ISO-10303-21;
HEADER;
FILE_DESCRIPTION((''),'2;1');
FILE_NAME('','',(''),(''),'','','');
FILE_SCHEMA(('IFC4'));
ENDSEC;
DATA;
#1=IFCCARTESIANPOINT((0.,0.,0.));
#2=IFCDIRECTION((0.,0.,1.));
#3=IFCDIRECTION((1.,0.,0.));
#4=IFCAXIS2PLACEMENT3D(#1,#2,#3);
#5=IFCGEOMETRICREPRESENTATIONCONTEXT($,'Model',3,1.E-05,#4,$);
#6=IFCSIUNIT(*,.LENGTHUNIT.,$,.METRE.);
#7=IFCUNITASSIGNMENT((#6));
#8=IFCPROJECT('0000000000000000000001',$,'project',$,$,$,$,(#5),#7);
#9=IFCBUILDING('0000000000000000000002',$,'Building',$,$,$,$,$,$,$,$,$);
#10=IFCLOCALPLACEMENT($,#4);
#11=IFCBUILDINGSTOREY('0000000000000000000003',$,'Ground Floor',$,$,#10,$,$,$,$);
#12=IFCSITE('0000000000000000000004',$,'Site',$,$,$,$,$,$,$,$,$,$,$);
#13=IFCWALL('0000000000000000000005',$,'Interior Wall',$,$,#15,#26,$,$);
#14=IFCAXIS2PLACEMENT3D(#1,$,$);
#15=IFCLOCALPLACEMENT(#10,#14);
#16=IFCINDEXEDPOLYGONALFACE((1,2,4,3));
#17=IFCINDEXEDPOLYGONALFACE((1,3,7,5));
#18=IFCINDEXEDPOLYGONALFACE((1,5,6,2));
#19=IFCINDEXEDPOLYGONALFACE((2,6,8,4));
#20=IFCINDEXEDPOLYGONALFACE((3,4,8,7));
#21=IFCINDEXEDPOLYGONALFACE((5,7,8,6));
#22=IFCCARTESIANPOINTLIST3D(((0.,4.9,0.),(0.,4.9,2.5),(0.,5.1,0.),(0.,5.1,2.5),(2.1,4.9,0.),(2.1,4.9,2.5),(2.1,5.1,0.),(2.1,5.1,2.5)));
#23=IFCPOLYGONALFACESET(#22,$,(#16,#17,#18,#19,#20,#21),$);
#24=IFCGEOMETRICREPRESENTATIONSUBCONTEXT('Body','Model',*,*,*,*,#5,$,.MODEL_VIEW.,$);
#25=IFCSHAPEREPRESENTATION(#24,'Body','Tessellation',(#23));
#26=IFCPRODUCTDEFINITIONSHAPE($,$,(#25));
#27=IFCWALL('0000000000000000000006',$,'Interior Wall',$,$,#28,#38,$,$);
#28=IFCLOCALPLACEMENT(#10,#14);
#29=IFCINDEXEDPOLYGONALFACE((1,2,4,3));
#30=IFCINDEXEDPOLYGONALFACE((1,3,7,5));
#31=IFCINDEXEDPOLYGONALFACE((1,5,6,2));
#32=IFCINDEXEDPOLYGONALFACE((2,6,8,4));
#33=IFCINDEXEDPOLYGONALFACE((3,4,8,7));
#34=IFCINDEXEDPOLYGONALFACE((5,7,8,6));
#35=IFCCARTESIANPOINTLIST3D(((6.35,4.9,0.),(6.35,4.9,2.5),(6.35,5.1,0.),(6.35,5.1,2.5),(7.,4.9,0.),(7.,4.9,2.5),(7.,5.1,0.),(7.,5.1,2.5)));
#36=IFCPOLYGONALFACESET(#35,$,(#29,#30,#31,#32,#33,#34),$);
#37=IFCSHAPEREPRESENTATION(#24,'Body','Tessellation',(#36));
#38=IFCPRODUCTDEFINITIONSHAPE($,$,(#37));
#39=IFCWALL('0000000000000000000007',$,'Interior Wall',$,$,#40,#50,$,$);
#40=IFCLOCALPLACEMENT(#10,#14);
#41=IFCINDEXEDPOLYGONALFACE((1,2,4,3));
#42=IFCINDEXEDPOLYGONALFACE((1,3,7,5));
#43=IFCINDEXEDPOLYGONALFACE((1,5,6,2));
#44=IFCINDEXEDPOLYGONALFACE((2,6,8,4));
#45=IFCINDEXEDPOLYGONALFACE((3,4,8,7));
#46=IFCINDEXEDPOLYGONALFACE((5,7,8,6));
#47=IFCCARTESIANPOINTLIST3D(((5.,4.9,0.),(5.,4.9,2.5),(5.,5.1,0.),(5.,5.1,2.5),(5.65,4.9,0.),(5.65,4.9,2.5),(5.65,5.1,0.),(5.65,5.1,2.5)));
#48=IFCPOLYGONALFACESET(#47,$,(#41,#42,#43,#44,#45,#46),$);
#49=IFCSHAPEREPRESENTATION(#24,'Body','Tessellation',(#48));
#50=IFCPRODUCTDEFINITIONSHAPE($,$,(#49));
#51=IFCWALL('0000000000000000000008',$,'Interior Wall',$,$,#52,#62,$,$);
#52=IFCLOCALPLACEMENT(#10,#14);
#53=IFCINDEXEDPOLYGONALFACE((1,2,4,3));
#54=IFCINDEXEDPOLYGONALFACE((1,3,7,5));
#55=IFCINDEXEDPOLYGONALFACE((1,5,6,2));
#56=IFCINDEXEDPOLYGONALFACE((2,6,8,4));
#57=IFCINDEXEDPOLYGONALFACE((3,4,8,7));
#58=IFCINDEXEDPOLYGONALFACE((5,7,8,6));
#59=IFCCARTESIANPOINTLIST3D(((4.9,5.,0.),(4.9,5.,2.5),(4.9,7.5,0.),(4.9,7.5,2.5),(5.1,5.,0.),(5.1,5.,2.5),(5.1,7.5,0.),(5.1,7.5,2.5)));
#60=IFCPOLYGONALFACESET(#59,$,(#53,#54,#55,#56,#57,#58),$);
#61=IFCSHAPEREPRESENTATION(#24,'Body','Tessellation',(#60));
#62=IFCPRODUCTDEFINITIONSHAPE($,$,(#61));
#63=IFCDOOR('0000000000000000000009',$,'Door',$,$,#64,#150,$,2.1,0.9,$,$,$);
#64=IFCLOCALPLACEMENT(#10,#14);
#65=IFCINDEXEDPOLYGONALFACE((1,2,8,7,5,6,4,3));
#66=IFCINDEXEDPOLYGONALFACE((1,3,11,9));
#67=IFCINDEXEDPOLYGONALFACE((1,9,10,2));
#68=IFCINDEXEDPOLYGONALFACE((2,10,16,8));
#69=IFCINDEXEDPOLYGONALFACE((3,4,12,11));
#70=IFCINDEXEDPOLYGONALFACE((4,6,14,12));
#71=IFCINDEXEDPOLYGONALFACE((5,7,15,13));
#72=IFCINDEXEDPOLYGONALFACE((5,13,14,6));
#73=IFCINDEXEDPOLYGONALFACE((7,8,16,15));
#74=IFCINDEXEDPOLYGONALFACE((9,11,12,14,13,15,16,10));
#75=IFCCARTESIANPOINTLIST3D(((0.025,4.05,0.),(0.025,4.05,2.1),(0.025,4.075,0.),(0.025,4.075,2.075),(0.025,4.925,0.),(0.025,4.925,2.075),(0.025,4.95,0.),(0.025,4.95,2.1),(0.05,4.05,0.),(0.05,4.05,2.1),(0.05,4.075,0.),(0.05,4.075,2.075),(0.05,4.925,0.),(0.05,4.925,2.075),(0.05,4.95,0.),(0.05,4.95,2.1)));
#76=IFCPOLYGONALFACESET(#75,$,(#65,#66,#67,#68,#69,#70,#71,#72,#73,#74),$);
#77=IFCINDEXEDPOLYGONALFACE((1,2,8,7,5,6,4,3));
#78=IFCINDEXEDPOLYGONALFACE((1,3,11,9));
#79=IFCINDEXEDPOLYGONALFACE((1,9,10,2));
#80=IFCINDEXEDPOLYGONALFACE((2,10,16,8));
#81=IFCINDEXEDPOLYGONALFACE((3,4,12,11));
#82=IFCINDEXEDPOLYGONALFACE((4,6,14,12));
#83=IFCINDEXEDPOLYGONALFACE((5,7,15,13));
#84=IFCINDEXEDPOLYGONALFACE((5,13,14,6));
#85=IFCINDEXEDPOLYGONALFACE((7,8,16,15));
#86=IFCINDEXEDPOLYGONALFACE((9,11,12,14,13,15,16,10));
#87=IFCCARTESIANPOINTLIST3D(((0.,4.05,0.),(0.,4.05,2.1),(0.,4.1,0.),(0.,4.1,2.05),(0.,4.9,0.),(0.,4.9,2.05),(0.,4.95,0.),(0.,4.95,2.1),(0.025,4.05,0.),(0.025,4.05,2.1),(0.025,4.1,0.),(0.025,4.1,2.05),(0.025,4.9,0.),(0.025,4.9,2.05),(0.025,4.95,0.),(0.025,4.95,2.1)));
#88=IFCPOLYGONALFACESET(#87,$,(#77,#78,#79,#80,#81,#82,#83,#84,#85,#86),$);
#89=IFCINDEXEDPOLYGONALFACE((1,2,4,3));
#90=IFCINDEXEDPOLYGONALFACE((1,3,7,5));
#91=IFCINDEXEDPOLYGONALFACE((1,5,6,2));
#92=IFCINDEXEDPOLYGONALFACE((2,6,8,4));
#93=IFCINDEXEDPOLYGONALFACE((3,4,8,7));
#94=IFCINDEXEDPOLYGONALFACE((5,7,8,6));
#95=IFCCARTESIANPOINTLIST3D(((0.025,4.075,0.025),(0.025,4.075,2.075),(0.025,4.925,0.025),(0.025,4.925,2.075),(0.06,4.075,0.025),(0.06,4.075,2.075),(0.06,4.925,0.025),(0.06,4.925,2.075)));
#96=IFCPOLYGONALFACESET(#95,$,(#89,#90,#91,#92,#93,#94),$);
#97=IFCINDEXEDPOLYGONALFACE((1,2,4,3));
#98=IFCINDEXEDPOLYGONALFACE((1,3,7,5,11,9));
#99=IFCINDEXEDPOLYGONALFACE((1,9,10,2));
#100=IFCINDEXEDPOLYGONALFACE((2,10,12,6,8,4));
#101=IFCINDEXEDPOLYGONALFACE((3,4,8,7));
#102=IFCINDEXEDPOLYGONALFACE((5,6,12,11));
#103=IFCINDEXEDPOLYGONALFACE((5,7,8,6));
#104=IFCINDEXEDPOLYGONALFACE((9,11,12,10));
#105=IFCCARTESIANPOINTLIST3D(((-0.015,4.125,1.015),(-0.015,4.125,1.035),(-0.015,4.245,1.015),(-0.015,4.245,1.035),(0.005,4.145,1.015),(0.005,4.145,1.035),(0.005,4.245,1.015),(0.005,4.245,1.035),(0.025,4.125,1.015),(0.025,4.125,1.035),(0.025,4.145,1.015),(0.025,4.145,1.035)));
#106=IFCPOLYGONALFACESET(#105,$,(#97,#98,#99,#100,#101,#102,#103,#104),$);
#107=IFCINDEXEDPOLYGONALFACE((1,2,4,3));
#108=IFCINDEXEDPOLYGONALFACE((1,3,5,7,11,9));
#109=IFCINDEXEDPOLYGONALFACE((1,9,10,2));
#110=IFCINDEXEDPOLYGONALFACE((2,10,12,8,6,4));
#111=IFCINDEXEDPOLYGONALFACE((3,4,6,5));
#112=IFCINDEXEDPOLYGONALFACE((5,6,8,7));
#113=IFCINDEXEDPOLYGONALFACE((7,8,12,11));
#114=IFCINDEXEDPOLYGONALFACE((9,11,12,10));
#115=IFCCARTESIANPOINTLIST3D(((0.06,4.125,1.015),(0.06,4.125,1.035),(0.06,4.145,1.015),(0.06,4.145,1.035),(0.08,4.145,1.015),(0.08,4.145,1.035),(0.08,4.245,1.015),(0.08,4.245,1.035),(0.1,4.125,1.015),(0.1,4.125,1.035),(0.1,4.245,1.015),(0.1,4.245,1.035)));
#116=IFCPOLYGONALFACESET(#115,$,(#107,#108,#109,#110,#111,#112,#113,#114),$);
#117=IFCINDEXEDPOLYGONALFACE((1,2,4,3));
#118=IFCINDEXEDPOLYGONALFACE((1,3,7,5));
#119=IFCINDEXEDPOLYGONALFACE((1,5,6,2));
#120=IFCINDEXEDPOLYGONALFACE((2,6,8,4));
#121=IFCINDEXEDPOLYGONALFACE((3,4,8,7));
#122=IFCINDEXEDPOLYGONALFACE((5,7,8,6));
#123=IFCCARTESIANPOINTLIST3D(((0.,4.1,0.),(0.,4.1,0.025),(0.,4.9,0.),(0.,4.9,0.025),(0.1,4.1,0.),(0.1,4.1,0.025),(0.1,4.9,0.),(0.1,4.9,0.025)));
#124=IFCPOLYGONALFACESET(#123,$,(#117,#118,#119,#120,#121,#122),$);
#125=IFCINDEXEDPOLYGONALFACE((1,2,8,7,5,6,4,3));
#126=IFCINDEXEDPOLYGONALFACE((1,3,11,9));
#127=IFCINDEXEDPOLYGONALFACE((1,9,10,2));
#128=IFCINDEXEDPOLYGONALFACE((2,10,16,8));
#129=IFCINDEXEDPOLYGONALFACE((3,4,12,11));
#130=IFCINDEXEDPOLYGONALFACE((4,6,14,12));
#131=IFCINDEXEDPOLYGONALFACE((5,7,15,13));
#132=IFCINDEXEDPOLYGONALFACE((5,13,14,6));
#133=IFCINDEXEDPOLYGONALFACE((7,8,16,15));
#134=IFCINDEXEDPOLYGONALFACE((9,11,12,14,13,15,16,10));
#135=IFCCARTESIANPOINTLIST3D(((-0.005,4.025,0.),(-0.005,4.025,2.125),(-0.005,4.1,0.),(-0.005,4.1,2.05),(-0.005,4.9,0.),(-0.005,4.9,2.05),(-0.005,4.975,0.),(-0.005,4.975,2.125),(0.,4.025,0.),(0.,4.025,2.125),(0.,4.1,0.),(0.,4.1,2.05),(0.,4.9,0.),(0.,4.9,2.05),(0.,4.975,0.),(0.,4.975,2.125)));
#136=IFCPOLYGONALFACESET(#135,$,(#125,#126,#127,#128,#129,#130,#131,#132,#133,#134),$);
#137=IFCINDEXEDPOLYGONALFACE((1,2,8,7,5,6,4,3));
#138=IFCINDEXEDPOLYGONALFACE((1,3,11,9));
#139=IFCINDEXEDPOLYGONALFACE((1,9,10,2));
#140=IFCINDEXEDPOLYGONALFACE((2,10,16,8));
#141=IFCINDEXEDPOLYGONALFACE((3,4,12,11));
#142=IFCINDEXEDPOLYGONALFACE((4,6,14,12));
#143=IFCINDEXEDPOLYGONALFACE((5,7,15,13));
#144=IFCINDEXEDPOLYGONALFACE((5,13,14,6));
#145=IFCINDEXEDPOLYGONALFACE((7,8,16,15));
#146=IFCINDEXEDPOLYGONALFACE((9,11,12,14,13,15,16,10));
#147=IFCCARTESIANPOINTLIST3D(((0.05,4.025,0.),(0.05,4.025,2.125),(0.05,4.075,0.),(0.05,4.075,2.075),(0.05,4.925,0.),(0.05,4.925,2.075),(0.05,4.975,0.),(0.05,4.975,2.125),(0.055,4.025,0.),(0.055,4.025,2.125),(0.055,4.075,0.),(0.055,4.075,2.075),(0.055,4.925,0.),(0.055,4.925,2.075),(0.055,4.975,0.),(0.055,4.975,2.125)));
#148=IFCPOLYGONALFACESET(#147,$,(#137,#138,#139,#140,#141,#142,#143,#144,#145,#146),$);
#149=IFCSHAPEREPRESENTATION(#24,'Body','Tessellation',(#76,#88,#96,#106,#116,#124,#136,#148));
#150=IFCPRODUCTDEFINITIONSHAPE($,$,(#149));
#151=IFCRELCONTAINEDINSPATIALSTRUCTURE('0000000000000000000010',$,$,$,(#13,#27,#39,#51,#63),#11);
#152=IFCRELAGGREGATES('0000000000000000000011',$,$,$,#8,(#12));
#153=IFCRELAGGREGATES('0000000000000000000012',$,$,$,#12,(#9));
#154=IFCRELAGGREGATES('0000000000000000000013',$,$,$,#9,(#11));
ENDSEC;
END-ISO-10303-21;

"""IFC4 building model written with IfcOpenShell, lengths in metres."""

from ifc_helpers import new_model, si_unit, frame, origin_with_axes, place, context, subcontext, project, spatial, line, indexed_curve, outline, extrude, element, save


model = new_model("IFC4")

# Units and contexts
model_context = context("Model", 3, precision=1e-05, world=origin_with_axes())
body_context = subcontext(model_context, "Body", "Model", "MODEL_VIEW")
ifc_project = project(units=[si_unit("LENGTHUNIT", "METRE")], contexts=[model_context])

# Site, building, storey
site = spatial("IfcSite", under=ifc_project, Name="Site")
building = spatial("IfcBuilding", under=site, Name="Building")
storey_placement = place(None, origin_with_axes())
storey = spatial("IfcBuildingStorey", under=building, at=storey_placement, Name="Ground Floor")

# Walls
for number, where, z_axis, x_axis, name in (
    (1, (2.1, 5.0, 0.0), (0.0, 0.0, 1.0), (-1.0, 0.0, 0.0), "Interior Wall"),
):
    element("IfcWall", number, at=place(storey_placement, frame(where, z_axis=z_axis, x_axis=x_axis)), inside=storey, Name=name, context=body_context, shape_type="SweptSolid", body=[
        extrude(outline(indexed_curve([(0.0, 0.0), (0.0, 0.2), (2.1, 0.2), (2.1, 0.0), (0.0, 0.0)], self_intersect=False)), frame((0.0, -0.1, 0.0), z_axis=(0.0, 0.0, 1.0), x_axis=(1.0, 0.0, 0.0)), (0.0, 0.0, 1.0), 2.5),
    ])
for number, where, z_axis, x_axis, name in (
    (2, (7.0, 5.0, 0.0), (0.0, 0.0, 1.0), (-1.0, 0.0, 0.0), "Interior Wall"),
    (3, (5.65, 5.0, 0.0), (0.0, 0.0, 1.0), (-1.0, 0.0, 0.0), "Interior Wall"),
):
    element("IfcWall", number, at=place(storey_placement, frame(where, z_axis=z_axis, x_axis=x_axis)), inside=storey, Name=name, context=body_context, shape_type="SweptSolid", body=[
        extrude(outline(indexed_curve([(0.0, 0.0), (0.0, 0.2), (0.65, 0.2), (0.65, 0.0), (0.0, 0.0)], self_intersect=False)), frame((0.0, -0.1, 0.0), z_axis=(0.0, 0.0, 1.0), x_axis=(1.0, 0.0, 0.0)), (0.0, 0.0, 1.0), 2.5),
    ])
wall_1_placement = place(storey_placement, frame((5.0, 5.0, 0.0), z_axis=(0.0, 0.0, 1.0), x_axis=(0.0, 1.0, 0.0)))
element("IfcWall", 4, at=wall_1_placement, inside=storey, Name="Interior Wall", context=body_context, shape_type="SweptSolid", body=[
    extrude(outline(indexed_curve([(0.0, 0.0), (0.0, 0.2), (2.5, 0.2), (2.5, 0.0), (0.0, 0.0)], self_intersect=False)), frame((0.0, -0.1, 0.0), z_axis=(0.0, 0.0, 1.0), x_axis=(1.0, 0.0, 0.0)), (0.0, 0.0, 1.0), 2.5),
])

# Door
door_1_placement = place(storey_placement, frame((0.0, 4.95, 0.0), z_axis=(0.0, 0.0, 1.0), x_axis=(0.0, -1.0, 0.0)))
element("IfcDoor", 5, at=door_1_placement, inside=storey, Name="Door", OverallHeight=2.1, OverallWidth=0.9, context=body_context, shape_type="SweptSolid", body=[
    extrude(outline(indexed_curve([(0.0, 0.0), (0.0, 2.1), (0.9, 2.1), (0.9, 0.0), (0.875, 0.0), (0.875, 2.075), (0.025, 2.075), (0.025, 0.0)], segments=[line(1, 2, 3, 4, 5, 6, 7, 8, 1)])), frame((0.0, 0.025, 0.0), z_axis=(0.0, -1.0, 0.0), x_axis=(1.0, 0.0, 0.0)), (0.0, 0.0, -1.0), 0.025),
    extrude(outline(indexed_curve([(0.0, 0.0), (0.0, 2.1), (0.9, 2.1), (0.9, 0.0), (0.85, 0.0), (0.85, 2.05), (0.05, 2.05), (0.05, 0.0)], segments=[line(1, 2, 3, 4, 5, 6, 7, 8, 1)])), frame((0.0, 0.0, 0.0), z_axis=(0.0, -1.0, 0.0), x_axis=(1.0, 0.0, 0.0)), (0.0, 0.0, -1.0), 0.025),
    extrude(outline(indexed_curve([(0.0, 0.0), (0.85, 0.0), (0.85, 0.035), (0.0, 0.035)], segments=[line(1, 2, 3, 4, 1)])), frame((0.025, 0.025, 0.025), z_axis=(0.0, 0.0, 1.0), x_axis=(1.0, 0.0, 0.0)), (0.0, 0.0, 1.0), 2.05),
    extrude(outline(indexed_curve([(0.0, 0.0), (0.0, -0.04), (-0.12, -0.04), (-0.12, -0.02), (-0.02, -0.02), (-0.02, 0.0)], segments=[line(1, 2, 3, 4, 5, 6, 1)])), frame((0.825, 0.025, 1.015), z_axis=(0.0, 0.0, 1.0), x_axis=(1.0, 0.0, 0.0)), (0.0, 0.0, 1.0), 0.02),
    extrude(outline(indexed_curve([(0.0, 0.0), (0.0, 0.04), (-0.12, 0.04), (-0.12, 0.02), (-0.02, 0.02), (-0.02, 0.0)], segments=[line(1, 2, 3, 4, 5, 6, 1)])), frame((0.825, 0.06, 1.015), z_axis=(0.0, 0.0, 1.0), x_axis=(1.0, 0.0, 0.0)), (0.0, 0.0, 1.0), 0.02),
    extrude(outline(indexed_curve([(0.0, 0.0), (0.8, 0.0), (0.8, 0.1), (0.0, 0.1)], segments=[line(1, 2, 3, 4, 1)])), frame((0.05, 0.0, 0.0), z_axis=(0.0, 0.0, 1.0), x_axis=(1.0, 0.0, 0.0)), (0.0, 0.0, 1.0), 0.025),
    extrude(outline(indexed_curve([(0.0, 0.0), (0.0, 2.125), (0.95, 2.125), (0.95, 0.0), (0.875, 0.0), (0.875, 2.05), (0.075, 2.05), (0.075, 0.0)], segments=[line(1, 2, 3, 4, 5, 6, 7, 8, 1)])), frame((-0.025, -0.005, 0.0), z_axis=(0.0, -1.0, 0.0), x_axis=(1.0, 0.0, 0.0)), (0.0, 0.0, -1.0), 0.005),
    extrude(outline(indexed_curve([(0.0, 0.0), (0.0, 2.125), (0.95, 2.125), (0.95, 0.0), (0.9, 0.0), (0.9, 2.075), (0.05, 2.075), (0.05, 0.0)], segments=[line(1, 2, 3, 4, 5, 6, 7, 8, 1)])), frame((-0.025, 0.05, 0.0), z_axis=(0.0, -1.0, 0.0), x_axis=(1.0, 0.0, 0.0)), (0.0, 0.0, -1.0), 0.005),
])

save(model, "model.ifc")
